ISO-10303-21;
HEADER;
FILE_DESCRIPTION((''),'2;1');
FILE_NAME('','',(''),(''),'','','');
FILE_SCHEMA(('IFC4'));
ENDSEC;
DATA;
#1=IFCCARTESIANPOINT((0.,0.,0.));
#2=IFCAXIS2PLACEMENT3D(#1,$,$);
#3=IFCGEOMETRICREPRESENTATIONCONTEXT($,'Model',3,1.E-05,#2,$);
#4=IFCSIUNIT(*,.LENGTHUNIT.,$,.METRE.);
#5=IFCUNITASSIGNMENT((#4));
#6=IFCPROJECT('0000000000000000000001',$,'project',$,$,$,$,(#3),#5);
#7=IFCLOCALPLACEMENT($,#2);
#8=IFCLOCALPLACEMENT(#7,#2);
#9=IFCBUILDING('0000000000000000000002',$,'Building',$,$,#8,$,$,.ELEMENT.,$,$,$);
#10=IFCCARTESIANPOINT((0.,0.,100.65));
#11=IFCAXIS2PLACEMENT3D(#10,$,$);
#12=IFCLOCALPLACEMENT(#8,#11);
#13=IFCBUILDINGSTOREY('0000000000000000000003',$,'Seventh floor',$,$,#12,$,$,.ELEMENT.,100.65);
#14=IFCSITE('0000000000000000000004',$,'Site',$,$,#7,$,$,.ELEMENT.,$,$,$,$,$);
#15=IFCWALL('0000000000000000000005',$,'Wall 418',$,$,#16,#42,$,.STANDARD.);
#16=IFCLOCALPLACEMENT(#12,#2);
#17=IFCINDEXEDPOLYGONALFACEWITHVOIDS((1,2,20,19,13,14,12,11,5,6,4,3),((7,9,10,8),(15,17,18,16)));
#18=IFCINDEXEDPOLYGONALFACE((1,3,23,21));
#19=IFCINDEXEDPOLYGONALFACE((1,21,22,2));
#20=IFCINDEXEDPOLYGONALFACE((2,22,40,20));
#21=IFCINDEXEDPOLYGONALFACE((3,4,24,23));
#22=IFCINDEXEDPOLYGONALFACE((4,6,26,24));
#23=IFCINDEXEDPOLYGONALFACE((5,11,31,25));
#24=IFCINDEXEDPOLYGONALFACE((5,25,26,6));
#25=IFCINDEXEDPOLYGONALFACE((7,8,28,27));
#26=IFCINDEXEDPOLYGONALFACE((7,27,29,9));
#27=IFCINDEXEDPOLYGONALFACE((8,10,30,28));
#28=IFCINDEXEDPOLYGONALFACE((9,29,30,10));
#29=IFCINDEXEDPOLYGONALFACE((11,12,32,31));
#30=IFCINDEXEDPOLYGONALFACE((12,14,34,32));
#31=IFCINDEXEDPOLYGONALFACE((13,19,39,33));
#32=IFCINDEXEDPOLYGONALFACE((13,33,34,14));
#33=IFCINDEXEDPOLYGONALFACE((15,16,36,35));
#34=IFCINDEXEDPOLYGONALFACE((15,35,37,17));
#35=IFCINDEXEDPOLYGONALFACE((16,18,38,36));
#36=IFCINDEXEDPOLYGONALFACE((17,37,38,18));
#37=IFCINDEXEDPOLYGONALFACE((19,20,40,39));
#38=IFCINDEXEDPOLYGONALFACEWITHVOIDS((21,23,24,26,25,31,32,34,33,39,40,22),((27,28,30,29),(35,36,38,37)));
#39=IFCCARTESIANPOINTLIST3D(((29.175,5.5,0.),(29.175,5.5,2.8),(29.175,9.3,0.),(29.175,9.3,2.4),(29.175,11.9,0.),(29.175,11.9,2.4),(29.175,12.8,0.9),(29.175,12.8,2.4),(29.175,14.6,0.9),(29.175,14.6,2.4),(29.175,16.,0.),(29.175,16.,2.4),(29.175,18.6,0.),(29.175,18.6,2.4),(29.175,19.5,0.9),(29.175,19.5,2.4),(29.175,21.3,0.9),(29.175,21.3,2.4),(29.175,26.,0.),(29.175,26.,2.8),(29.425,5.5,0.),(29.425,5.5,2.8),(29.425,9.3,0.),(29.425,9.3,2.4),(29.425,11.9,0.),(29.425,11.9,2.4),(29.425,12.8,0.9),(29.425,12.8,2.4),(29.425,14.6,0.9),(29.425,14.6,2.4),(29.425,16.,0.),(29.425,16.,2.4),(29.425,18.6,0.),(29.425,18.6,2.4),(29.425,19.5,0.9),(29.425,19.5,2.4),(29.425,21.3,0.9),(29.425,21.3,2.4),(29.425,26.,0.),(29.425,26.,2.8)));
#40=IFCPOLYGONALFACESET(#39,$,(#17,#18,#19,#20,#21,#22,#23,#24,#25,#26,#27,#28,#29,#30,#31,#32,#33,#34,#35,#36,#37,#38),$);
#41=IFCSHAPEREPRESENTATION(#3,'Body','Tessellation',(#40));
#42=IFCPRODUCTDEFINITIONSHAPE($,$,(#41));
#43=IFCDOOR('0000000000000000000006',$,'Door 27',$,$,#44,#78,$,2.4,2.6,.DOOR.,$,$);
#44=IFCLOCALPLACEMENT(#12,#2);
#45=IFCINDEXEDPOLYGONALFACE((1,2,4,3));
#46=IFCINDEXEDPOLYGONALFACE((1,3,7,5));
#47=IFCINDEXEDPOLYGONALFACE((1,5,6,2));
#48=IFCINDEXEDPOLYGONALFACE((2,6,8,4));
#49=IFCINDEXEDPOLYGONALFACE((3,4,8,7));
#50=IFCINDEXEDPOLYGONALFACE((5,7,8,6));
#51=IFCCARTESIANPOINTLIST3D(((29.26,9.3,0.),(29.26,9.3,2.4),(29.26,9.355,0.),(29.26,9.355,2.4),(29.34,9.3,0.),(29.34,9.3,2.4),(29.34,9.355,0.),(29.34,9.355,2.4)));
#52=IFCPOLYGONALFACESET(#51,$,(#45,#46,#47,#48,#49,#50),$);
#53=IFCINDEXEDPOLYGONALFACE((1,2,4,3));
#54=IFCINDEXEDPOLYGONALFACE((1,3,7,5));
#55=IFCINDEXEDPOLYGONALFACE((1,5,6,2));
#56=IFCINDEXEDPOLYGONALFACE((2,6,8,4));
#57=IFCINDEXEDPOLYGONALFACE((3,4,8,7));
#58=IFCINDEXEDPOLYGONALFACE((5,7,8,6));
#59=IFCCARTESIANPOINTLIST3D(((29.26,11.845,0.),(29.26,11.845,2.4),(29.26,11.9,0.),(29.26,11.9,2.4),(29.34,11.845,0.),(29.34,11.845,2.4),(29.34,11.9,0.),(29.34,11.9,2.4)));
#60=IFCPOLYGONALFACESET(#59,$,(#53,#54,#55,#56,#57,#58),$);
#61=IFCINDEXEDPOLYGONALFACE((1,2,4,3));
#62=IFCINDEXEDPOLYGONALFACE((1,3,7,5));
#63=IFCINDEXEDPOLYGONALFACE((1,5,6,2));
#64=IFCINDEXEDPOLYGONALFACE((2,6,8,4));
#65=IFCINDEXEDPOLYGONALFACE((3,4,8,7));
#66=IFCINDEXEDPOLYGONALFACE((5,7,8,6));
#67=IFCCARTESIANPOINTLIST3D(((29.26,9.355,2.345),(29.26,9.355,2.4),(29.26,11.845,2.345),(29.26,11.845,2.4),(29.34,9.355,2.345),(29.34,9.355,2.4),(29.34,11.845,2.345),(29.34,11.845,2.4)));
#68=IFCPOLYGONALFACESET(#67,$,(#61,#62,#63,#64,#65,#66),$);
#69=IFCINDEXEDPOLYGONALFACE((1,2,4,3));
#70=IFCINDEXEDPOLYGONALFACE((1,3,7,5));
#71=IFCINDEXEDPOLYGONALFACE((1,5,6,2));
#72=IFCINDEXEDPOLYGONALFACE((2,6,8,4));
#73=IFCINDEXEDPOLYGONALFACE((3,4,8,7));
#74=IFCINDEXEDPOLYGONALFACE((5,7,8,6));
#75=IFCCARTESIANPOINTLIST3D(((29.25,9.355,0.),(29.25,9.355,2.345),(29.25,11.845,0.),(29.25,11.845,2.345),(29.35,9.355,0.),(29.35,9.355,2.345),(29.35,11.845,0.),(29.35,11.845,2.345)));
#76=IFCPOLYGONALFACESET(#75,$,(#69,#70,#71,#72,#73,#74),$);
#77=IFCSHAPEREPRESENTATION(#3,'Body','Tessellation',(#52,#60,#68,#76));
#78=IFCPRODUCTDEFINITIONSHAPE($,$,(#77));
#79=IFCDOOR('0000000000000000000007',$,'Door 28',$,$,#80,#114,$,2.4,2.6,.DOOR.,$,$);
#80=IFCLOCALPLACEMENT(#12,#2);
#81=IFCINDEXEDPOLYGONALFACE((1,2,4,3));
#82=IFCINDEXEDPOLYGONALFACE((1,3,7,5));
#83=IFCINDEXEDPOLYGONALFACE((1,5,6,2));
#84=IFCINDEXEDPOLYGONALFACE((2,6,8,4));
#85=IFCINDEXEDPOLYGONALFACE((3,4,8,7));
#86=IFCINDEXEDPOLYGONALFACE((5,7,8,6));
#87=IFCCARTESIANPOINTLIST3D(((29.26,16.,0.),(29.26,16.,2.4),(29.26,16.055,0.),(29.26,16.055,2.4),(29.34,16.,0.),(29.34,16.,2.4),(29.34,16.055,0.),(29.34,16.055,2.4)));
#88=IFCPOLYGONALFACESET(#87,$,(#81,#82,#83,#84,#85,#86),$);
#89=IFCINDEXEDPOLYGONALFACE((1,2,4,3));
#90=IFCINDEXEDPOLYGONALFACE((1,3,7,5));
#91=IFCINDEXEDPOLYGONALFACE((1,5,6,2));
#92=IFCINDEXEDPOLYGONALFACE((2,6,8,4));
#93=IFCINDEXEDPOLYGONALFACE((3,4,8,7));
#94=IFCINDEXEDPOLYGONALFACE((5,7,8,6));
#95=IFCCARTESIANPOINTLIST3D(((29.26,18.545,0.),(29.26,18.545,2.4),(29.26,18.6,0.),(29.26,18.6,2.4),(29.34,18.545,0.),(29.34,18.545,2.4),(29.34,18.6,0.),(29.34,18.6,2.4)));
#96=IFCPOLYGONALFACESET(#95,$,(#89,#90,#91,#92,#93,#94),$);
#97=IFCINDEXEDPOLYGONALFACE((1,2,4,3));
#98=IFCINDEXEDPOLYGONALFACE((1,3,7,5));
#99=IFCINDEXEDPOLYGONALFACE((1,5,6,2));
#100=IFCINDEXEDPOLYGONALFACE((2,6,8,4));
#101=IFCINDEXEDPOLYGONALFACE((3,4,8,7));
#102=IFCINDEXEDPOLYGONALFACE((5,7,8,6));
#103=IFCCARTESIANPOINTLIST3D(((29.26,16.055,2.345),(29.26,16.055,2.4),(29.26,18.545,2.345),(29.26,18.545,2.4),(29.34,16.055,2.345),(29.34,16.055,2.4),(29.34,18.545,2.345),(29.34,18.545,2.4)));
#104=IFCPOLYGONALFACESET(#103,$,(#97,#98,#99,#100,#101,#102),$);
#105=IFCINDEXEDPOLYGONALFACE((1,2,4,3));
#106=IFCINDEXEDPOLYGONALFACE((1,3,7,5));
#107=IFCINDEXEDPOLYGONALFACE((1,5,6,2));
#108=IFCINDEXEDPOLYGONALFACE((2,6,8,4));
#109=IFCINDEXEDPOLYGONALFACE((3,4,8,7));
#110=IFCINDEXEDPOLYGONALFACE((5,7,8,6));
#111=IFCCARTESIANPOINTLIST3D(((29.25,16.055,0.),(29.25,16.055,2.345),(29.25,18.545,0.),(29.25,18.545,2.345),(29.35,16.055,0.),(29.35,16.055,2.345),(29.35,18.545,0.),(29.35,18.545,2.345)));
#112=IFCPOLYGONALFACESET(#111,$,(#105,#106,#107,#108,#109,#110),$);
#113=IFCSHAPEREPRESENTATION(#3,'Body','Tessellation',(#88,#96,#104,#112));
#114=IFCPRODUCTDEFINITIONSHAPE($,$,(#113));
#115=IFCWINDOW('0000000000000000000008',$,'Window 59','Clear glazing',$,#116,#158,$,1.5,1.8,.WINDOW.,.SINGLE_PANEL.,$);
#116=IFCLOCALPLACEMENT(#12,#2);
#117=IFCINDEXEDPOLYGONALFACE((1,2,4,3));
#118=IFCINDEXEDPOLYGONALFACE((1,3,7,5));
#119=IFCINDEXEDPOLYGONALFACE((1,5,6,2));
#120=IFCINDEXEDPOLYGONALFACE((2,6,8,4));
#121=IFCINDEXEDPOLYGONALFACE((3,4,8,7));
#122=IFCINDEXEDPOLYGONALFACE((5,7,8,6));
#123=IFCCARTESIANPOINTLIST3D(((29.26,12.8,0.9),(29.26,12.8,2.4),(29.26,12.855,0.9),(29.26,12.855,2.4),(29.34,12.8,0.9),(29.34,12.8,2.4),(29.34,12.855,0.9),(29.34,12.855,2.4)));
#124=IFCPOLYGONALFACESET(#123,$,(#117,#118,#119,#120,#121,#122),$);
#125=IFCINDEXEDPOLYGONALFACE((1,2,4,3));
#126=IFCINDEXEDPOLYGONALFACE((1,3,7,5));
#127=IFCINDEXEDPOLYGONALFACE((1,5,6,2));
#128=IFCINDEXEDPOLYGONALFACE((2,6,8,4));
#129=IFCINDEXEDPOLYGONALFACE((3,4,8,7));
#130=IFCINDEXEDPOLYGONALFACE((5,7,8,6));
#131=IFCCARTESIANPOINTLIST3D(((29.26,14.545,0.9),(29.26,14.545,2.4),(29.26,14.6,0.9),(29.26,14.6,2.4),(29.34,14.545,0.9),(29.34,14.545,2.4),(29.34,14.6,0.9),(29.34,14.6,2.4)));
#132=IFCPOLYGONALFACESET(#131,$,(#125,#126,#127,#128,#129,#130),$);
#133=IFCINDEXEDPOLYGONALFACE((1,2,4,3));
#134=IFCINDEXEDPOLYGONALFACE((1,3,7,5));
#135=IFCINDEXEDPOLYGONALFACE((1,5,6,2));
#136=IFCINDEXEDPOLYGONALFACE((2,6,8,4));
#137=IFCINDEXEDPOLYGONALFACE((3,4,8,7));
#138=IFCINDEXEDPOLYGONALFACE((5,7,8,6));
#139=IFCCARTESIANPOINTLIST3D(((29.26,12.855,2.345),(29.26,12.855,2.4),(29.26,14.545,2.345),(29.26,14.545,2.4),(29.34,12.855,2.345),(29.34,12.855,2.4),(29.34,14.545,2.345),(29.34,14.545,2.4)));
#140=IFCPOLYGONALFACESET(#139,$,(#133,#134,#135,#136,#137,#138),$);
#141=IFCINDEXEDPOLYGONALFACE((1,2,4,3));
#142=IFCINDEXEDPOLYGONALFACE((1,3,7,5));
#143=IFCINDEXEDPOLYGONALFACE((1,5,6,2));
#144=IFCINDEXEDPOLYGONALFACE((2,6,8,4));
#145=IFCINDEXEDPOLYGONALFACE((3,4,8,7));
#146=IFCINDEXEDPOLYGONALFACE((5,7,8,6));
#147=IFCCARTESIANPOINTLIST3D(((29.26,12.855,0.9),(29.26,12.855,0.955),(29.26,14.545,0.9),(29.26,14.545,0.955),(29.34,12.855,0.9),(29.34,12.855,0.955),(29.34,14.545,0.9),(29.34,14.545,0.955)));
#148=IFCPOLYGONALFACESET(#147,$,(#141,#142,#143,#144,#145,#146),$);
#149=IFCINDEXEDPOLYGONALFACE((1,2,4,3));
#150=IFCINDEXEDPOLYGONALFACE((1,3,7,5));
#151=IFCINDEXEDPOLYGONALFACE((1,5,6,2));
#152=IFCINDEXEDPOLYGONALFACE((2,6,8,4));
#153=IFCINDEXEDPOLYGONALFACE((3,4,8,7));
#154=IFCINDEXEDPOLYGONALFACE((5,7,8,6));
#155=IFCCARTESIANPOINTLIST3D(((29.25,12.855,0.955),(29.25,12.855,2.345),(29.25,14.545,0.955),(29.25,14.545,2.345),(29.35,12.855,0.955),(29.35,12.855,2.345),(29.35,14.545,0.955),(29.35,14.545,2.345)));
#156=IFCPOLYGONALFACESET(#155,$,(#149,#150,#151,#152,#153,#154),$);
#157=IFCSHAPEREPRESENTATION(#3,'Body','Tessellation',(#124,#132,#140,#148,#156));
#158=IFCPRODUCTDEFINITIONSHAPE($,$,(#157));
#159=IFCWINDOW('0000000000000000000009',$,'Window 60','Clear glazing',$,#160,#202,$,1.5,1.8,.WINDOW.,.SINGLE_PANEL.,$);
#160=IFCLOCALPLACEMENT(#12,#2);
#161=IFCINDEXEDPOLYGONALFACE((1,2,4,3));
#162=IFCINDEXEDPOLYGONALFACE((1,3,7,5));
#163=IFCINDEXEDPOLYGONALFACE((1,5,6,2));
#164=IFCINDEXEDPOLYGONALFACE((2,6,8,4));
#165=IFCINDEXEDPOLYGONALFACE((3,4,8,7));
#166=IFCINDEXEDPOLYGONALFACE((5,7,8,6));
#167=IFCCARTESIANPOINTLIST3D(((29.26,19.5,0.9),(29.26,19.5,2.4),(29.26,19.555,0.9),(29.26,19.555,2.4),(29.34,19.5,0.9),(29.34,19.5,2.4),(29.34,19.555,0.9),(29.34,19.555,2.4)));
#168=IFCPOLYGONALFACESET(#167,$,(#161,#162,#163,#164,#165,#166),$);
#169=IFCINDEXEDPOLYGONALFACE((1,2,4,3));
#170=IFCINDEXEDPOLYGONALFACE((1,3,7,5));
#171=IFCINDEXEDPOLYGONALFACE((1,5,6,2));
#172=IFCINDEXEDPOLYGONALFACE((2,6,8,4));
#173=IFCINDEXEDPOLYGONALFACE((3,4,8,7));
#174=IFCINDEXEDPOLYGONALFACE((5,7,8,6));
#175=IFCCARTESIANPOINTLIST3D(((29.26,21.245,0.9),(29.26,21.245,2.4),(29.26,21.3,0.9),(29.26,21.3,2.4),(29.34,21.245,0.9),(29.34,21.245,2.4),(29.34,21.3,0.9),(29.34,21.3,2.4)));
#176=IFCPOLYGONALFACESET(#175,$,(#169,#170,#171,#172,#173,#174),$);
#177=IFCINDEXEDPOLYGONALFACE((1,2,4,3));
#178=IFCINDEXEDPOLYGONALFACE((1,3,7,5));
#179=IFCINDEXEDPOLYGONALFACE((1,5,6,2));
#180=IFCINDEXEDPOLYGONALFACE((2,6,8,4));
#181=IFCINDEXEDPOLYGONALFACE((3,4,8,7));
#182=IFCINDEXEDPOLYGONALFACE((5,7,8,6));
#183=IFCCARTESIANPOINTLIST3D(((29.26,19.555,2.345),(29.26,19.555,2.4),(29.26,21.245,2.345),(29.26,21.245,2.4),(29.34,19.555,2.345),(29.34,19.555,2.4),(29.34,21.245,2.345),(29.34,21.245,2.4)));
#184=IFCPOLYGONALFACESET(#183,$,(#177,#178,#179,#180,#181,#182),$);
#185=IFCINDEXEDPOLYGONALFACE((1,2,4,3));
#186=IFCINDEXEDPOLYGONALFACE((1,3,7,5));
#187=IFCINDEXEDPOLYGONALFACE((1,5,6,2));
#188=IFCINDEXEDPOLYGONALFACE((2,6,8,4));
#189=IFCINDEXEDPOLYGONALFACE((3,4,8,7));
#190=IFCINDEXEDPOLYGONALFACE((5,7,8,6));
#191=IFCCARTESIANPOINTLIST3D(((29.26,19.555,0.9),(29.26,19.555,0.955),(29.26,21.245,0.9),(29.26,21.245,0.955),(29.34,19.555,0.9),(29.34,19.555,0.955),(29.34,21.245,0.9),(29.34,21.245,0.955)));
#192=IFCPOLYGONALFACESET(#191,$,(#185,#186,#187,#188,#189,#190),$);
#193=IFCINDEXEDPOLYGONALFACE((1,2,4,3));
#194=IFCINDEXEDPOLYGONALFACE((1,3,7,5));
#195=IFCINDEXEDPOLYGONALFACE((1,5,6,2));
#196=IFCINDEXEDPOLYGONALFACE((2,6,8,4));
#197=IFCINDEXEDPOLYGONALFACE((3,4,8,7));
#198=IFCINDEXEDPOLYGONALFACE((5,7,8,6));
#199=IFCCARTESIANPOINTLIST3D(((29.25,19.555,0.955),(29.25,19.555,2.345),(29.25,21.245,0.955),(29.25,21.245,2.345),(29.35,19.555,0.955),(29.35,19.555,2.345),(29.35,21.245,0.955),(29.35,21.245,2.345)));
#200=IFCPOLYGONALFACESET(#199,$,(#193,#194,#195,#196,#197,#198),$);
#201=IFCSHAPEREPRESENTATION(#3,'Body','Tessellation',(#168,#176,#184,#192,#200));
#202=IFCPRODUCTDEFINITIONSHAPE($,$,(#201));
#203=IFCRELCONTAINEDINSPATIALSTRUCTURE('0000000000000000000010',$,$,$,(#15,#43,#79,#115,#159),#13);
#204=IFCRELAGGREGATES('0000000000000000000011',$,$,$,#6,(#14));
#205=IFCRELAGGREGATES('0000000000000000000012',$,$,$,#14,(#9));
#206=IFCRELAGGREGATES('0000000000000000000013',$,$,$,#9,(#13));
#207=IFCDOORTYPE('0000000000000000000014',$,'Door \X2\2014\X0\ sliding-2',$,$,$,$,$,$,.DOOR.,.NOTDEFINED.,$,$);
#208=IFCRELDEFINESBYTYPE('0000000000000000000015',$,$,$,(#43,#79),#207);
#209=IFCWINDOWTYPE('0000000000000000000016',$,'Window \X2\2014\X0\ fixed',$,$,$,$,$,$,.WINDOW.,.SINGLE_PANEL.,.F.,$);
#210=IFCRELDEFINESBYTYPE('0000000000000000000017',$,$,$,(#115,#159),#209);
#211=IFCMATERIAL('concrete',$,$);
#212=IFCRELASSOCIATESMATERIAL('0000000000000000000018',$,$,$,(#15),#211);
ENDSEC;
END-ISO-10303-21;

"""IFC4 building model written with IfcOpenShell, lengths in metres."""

from ifc_helpers import new_model, si_unit, frame, frame_2d, origin, place, context, project, spatial, rectangle, extrude, material, type_object, element, fill, save


model = new_model("IFC4")

# Units and contexts
model_context = context("Model", 3, precision=1e-05, world=origin())
ifc_project = project(units=[si_unit("LENGTHUNIT", "METRE")], contexts=[model_context])

# Site, building, storey
site_placement = place(None, origin())
site = spatial("IfcSite", under=ifc_project, at=site_placement, Name="Site", CompositionType="ELEMENT")
building_placement = place(site_placement, origin())
building = spatial("IfcBuilding", under=site, at=building_placement, Name="Building", CompositionType="ELEMENT")
storey_placement = place(building_placement, frame((0.0, 0.0, 100.65)))
storey = spatial("IfcBuildingStorey", under=building, at=storey_placement, Name="Seventh floor", CompositionType="ELEMENT", Elevation=100.65)

# Shared definitions
ifc_material = material(Name="concrete")

# Wall, openings, doors, windows
wall_1_placement = place(storey_placement, frame((29.3, 5.5, 0.0), z_axis=(0.0, 0.0, 1.0), x_axis=(0.0, 1.0, 0.0)))
wall_1 = element("IfcWall", 1, at=wall_1_placement, inside=storey, material=ifc_material, Name="Wall 418", PredefinedType="STANDARD", context=model_context, shape_type="SweptSolid", body=[
    extrude(rectangle(XDim=20.5, YDim=0.25, at=frame_2d((10.25, 0.0))), origin(), (0.0, 0.0, 1.0), 2.8),
])
opening_1_placement = place(storey_placement, frame((29.3, 9.3, 0.0), z_axis=(0.0, 0.0, 1.0), x_axis=(0.0, 1.0, 0.0)))
opening_1 = element("IfcOpeningElement", 2, at=opening_1_placement, cuts=wall_1, PredefinedType="OPENING", context=model_context, shape_type="SweptSolid", body=[
    extrude(rectangle(XDim=2.6, YDim=0.31, at=frame_2d((1.3, 0.0))), origin(), (0.0, 0.0, 1.0), 2.4),
])
opening_2_placement = place(storey_placement, frame((29.3, 12.8, 0.9), z_axis=(0.0, 0.0, 1.0), x_axis=(0.0, 1.0, 0.0)))
opening_2 = element("IfcOpeningElement", 3, at=opening_2_placement, cuts=wall_1, PredefinedType="OPENING", context=model_context, shape_type="SweptSolid", body=[
    extrude(rectangle(XDim=1.8, YDim=0.31, at=frame_2d((0.9, 0.0))), origin(), (0.0, 0.0, 1.0), 1.5),
])
opening_3_placement = place(storey_placement, frame((29.3, 16.0, 0.0), z_axis=(0.0, 0.0, 1.0), x_axis=(0.0, 1.0, 0.0)))
opening_3 = element("IfcOpeningElement", 4, at=opening_3_placement, cuts=wall_1, PredefinedType="OPENING", context=model_context, shape_type="SweptSolid", body=[
    extrude(rectangle(XDim=2.6, YDim=0.31, at=frame_2d((1.3, 0.0))), origin(), (0.0, 0.0, 1.0), 2.4),
])
opening_4_placement = place(storey_placement, frame((29.3, 19.5, 0.9), z_axis=(0.0, 0.0, 1.0), x_axis=(0.0, 1.0, 0.0)))
opening_4 = element("IfcOpeningElement", 5, at=opening_4_placement, cuts=wall_1, PredefinedType="OPENING", context=model_context, shape_type="SweptSolid", body=[
    extrude(rectangle(XDim=1.8, YDim=0.31, at=frame_2d((0.9, 0.0))), origin(), (0.0, 0.0, 1.0), 1.5),
])
door_type = type_object("IfcDoorType", Name="Door — sliding-2", PredefinedType="DOOR")
door_1_placement = place(storey_placement, frame((29.3, 9.3, 0.0), z_axis=(0.0, 0.0, 1.0), x_axis=(0.0, 1.0, 0.0)))
door_1 = element("IfcDoor", 6, at=door_1_placement, inside=storey, type_object=door_type, Name="Door 27", OverallHeight=2.4, OverallWidth=2.6, PredefinedType="DOOR", context=model_context, shape_type="SweptSolid", body=[
    extrude(rectangle(XDim=0.055, YDim=0.08, at=frame_2d((0.0275, 0.0))), origin(), (0.0, 0.0, 1.0), 2.4),
    extrude(rectangle(XDim=0.055, YDim=0.08, at=frame_2d((2.5725, 0.0))), origin(), (0.0, 0.0, 1.0), 2.4),
    extrude(rectangle(XDim=2.49, YDim=0.08, at=frame_2d((1.3, 0.0))), frame((0.0, 0.0, 2.345)), (0.0, 0.0, 1.0), 0.055),
    extrude(rectangle(XDim=2.49, YDim=0.1, at=frame_2d((1.3, 0.0))), origin(), (0.0, 0.0, 1.0), 2.345),
])
fill(opening_1, door_1)
door_2_placement = place(storey_placement, frame((29.3, 16.0, 0.0), z_axis=(0.0, 0.0, 1.0), x_axis=(0.0, 1.0, 0.0)))
door_2 = element("IfcDoor", 7, at=door_2_placement, inside=storey, type_object=door_type, Name="Door 28", OverallHeight=2.4, OverallWidth=2.6, PredefinedType="DOOR", context=model_context, shape_type="SweptSolid", body=[
    extrude(rectangle(XDim=0.055, YDim=0.08, at=frame_2d((0.0275, 0.0))), origin(), (0.0, 0.0, 1.0), 2.4),
    extrude(rectangle(XDim=0.055, YDim=0.08, at=frame_2d((2.5725, 0.0))), origin(), (0.0, 0.0, 1.0), 2.4),
    extrude(rectangle(XDim=2.49, YDim=0.08, at=frame_2d((1.3, 0.0))), frame((0.0, 0.0, 2.345)), (0.0, 0.0, 1.0), 0.055),
    extrude(rectangle(XDim=2.49, YDim=0.1, at=frame_2d((1.3, 0.0))), origin(), (0.0, 0.0, 1.0), 2.345),
])
fill(opening_3, door_2)
window_type = type_object("IfcWindowType", Name="Window — fixed", ParameterTakesPrecedence=False, PartitioningType="SINGLE_PANEL", PredefinedType="WINDOW")
window_1_placement = place(storey_placement, frame((29.3, 12.8, 0.9), z_axis=(0.0, 0.0, 1.0), x_axis=(0.0, 1.0, 0.0)))
window_1 = element("IfcWindow", 8, at=window_1_placement, inside=storey, type_object=window_type, Name="Window 59", Description="Clear glazing", OverallHeight=1.5, OverallWidth=1.8, PartitioningType="SINGLE_PANEL", PredefinedType="WINDOW", context=model_context, shape_type="SweptSolid", body=[
    extrude(rectangle(XDim=0.055, YDim=0.08, at=frame_2d((0.0275, 0.0))), origin(), (0.0, 0.0, 1.0), 1.5),
    extrude(rectangle(XDim=0.055, YDim=0.08, at=frame_2d((1.7725, 0.0))), origin(), (0.0, 0.0, 1.0), 1.5),
    extrude(rectangle(XDim=1.69, YDim=0.08, at=frame_2d((0.9, 0.0))), frame((0.0, 0.0, 1.445)), (0.0, 0.0, 1.0), 0.055),
    extrude(rectangle(XDim=1.69, YDim=0.08, at=frame_2d((0.9, 0.0))), origin(), (0.0, 0.0, 1.0), 0.055),
    extrude(rectangle(XDim=1.69, YDim=0.1, at=frame_2d((0.9, 0.0))), frame((0.0, 0.0, 0.055)), (0.0, 0.0, 1.0), 1.39),
])
fill(opening_2, window_1)
window_2_placement = place(storey_placement, frame((29.3, 19.5, 0.9), z_axis=(0.0, 0.0, 1.0), x_axis=(0.0, 1.0, 0.0)))
window_2 = element("IfcWindow", 9, at=window_2_placement, inside=storey, type_object=window_type, Name="Window 60", Description="Clear glazing", OverallHeight=1.5, OverallWidth=1.8, PartitioningType="SINGLE_PANEL", PredefinedType="WINDOW", context=model_context, shape_type="SweptSolid", body=[
    extrude(rectangle(XDim=0.055, YDim=0.08, at=frame_2d((0.0275, 0.0))), origin(), (0.0, 0.0, 1.0), 1.5),
    extrude(rectangle(XDim=0.055, YDim=0.08, at=frame_2d((1.7725, 0.0))), origin(), (0.0, 0.0, 1.0), 1.5),
    extrude(rectangle(XDim=1.69, YDim=0.08, at=frame_2d((0.9, 0.0))), frame((0.0, 0.0, 1.445)), (0.0, 0.0, 1.0), 0.055),
    extrude(rectangle(XDim=1.69, YDim=0.08, at=frame_2d((0.9, 0.0))), origin(), (0.0, 0.0, 1.0), 0.055),
    extrude(rectangle(XDim=1.69, YDim=0.1, at=frame_2d((0.9, 0.0))), frame((0.0, 0.0, 0.055)), (0.0, 0.0, 1.0), 1.39),
])
fill(opening_4, window_2)

save(model, "model.ifc")
